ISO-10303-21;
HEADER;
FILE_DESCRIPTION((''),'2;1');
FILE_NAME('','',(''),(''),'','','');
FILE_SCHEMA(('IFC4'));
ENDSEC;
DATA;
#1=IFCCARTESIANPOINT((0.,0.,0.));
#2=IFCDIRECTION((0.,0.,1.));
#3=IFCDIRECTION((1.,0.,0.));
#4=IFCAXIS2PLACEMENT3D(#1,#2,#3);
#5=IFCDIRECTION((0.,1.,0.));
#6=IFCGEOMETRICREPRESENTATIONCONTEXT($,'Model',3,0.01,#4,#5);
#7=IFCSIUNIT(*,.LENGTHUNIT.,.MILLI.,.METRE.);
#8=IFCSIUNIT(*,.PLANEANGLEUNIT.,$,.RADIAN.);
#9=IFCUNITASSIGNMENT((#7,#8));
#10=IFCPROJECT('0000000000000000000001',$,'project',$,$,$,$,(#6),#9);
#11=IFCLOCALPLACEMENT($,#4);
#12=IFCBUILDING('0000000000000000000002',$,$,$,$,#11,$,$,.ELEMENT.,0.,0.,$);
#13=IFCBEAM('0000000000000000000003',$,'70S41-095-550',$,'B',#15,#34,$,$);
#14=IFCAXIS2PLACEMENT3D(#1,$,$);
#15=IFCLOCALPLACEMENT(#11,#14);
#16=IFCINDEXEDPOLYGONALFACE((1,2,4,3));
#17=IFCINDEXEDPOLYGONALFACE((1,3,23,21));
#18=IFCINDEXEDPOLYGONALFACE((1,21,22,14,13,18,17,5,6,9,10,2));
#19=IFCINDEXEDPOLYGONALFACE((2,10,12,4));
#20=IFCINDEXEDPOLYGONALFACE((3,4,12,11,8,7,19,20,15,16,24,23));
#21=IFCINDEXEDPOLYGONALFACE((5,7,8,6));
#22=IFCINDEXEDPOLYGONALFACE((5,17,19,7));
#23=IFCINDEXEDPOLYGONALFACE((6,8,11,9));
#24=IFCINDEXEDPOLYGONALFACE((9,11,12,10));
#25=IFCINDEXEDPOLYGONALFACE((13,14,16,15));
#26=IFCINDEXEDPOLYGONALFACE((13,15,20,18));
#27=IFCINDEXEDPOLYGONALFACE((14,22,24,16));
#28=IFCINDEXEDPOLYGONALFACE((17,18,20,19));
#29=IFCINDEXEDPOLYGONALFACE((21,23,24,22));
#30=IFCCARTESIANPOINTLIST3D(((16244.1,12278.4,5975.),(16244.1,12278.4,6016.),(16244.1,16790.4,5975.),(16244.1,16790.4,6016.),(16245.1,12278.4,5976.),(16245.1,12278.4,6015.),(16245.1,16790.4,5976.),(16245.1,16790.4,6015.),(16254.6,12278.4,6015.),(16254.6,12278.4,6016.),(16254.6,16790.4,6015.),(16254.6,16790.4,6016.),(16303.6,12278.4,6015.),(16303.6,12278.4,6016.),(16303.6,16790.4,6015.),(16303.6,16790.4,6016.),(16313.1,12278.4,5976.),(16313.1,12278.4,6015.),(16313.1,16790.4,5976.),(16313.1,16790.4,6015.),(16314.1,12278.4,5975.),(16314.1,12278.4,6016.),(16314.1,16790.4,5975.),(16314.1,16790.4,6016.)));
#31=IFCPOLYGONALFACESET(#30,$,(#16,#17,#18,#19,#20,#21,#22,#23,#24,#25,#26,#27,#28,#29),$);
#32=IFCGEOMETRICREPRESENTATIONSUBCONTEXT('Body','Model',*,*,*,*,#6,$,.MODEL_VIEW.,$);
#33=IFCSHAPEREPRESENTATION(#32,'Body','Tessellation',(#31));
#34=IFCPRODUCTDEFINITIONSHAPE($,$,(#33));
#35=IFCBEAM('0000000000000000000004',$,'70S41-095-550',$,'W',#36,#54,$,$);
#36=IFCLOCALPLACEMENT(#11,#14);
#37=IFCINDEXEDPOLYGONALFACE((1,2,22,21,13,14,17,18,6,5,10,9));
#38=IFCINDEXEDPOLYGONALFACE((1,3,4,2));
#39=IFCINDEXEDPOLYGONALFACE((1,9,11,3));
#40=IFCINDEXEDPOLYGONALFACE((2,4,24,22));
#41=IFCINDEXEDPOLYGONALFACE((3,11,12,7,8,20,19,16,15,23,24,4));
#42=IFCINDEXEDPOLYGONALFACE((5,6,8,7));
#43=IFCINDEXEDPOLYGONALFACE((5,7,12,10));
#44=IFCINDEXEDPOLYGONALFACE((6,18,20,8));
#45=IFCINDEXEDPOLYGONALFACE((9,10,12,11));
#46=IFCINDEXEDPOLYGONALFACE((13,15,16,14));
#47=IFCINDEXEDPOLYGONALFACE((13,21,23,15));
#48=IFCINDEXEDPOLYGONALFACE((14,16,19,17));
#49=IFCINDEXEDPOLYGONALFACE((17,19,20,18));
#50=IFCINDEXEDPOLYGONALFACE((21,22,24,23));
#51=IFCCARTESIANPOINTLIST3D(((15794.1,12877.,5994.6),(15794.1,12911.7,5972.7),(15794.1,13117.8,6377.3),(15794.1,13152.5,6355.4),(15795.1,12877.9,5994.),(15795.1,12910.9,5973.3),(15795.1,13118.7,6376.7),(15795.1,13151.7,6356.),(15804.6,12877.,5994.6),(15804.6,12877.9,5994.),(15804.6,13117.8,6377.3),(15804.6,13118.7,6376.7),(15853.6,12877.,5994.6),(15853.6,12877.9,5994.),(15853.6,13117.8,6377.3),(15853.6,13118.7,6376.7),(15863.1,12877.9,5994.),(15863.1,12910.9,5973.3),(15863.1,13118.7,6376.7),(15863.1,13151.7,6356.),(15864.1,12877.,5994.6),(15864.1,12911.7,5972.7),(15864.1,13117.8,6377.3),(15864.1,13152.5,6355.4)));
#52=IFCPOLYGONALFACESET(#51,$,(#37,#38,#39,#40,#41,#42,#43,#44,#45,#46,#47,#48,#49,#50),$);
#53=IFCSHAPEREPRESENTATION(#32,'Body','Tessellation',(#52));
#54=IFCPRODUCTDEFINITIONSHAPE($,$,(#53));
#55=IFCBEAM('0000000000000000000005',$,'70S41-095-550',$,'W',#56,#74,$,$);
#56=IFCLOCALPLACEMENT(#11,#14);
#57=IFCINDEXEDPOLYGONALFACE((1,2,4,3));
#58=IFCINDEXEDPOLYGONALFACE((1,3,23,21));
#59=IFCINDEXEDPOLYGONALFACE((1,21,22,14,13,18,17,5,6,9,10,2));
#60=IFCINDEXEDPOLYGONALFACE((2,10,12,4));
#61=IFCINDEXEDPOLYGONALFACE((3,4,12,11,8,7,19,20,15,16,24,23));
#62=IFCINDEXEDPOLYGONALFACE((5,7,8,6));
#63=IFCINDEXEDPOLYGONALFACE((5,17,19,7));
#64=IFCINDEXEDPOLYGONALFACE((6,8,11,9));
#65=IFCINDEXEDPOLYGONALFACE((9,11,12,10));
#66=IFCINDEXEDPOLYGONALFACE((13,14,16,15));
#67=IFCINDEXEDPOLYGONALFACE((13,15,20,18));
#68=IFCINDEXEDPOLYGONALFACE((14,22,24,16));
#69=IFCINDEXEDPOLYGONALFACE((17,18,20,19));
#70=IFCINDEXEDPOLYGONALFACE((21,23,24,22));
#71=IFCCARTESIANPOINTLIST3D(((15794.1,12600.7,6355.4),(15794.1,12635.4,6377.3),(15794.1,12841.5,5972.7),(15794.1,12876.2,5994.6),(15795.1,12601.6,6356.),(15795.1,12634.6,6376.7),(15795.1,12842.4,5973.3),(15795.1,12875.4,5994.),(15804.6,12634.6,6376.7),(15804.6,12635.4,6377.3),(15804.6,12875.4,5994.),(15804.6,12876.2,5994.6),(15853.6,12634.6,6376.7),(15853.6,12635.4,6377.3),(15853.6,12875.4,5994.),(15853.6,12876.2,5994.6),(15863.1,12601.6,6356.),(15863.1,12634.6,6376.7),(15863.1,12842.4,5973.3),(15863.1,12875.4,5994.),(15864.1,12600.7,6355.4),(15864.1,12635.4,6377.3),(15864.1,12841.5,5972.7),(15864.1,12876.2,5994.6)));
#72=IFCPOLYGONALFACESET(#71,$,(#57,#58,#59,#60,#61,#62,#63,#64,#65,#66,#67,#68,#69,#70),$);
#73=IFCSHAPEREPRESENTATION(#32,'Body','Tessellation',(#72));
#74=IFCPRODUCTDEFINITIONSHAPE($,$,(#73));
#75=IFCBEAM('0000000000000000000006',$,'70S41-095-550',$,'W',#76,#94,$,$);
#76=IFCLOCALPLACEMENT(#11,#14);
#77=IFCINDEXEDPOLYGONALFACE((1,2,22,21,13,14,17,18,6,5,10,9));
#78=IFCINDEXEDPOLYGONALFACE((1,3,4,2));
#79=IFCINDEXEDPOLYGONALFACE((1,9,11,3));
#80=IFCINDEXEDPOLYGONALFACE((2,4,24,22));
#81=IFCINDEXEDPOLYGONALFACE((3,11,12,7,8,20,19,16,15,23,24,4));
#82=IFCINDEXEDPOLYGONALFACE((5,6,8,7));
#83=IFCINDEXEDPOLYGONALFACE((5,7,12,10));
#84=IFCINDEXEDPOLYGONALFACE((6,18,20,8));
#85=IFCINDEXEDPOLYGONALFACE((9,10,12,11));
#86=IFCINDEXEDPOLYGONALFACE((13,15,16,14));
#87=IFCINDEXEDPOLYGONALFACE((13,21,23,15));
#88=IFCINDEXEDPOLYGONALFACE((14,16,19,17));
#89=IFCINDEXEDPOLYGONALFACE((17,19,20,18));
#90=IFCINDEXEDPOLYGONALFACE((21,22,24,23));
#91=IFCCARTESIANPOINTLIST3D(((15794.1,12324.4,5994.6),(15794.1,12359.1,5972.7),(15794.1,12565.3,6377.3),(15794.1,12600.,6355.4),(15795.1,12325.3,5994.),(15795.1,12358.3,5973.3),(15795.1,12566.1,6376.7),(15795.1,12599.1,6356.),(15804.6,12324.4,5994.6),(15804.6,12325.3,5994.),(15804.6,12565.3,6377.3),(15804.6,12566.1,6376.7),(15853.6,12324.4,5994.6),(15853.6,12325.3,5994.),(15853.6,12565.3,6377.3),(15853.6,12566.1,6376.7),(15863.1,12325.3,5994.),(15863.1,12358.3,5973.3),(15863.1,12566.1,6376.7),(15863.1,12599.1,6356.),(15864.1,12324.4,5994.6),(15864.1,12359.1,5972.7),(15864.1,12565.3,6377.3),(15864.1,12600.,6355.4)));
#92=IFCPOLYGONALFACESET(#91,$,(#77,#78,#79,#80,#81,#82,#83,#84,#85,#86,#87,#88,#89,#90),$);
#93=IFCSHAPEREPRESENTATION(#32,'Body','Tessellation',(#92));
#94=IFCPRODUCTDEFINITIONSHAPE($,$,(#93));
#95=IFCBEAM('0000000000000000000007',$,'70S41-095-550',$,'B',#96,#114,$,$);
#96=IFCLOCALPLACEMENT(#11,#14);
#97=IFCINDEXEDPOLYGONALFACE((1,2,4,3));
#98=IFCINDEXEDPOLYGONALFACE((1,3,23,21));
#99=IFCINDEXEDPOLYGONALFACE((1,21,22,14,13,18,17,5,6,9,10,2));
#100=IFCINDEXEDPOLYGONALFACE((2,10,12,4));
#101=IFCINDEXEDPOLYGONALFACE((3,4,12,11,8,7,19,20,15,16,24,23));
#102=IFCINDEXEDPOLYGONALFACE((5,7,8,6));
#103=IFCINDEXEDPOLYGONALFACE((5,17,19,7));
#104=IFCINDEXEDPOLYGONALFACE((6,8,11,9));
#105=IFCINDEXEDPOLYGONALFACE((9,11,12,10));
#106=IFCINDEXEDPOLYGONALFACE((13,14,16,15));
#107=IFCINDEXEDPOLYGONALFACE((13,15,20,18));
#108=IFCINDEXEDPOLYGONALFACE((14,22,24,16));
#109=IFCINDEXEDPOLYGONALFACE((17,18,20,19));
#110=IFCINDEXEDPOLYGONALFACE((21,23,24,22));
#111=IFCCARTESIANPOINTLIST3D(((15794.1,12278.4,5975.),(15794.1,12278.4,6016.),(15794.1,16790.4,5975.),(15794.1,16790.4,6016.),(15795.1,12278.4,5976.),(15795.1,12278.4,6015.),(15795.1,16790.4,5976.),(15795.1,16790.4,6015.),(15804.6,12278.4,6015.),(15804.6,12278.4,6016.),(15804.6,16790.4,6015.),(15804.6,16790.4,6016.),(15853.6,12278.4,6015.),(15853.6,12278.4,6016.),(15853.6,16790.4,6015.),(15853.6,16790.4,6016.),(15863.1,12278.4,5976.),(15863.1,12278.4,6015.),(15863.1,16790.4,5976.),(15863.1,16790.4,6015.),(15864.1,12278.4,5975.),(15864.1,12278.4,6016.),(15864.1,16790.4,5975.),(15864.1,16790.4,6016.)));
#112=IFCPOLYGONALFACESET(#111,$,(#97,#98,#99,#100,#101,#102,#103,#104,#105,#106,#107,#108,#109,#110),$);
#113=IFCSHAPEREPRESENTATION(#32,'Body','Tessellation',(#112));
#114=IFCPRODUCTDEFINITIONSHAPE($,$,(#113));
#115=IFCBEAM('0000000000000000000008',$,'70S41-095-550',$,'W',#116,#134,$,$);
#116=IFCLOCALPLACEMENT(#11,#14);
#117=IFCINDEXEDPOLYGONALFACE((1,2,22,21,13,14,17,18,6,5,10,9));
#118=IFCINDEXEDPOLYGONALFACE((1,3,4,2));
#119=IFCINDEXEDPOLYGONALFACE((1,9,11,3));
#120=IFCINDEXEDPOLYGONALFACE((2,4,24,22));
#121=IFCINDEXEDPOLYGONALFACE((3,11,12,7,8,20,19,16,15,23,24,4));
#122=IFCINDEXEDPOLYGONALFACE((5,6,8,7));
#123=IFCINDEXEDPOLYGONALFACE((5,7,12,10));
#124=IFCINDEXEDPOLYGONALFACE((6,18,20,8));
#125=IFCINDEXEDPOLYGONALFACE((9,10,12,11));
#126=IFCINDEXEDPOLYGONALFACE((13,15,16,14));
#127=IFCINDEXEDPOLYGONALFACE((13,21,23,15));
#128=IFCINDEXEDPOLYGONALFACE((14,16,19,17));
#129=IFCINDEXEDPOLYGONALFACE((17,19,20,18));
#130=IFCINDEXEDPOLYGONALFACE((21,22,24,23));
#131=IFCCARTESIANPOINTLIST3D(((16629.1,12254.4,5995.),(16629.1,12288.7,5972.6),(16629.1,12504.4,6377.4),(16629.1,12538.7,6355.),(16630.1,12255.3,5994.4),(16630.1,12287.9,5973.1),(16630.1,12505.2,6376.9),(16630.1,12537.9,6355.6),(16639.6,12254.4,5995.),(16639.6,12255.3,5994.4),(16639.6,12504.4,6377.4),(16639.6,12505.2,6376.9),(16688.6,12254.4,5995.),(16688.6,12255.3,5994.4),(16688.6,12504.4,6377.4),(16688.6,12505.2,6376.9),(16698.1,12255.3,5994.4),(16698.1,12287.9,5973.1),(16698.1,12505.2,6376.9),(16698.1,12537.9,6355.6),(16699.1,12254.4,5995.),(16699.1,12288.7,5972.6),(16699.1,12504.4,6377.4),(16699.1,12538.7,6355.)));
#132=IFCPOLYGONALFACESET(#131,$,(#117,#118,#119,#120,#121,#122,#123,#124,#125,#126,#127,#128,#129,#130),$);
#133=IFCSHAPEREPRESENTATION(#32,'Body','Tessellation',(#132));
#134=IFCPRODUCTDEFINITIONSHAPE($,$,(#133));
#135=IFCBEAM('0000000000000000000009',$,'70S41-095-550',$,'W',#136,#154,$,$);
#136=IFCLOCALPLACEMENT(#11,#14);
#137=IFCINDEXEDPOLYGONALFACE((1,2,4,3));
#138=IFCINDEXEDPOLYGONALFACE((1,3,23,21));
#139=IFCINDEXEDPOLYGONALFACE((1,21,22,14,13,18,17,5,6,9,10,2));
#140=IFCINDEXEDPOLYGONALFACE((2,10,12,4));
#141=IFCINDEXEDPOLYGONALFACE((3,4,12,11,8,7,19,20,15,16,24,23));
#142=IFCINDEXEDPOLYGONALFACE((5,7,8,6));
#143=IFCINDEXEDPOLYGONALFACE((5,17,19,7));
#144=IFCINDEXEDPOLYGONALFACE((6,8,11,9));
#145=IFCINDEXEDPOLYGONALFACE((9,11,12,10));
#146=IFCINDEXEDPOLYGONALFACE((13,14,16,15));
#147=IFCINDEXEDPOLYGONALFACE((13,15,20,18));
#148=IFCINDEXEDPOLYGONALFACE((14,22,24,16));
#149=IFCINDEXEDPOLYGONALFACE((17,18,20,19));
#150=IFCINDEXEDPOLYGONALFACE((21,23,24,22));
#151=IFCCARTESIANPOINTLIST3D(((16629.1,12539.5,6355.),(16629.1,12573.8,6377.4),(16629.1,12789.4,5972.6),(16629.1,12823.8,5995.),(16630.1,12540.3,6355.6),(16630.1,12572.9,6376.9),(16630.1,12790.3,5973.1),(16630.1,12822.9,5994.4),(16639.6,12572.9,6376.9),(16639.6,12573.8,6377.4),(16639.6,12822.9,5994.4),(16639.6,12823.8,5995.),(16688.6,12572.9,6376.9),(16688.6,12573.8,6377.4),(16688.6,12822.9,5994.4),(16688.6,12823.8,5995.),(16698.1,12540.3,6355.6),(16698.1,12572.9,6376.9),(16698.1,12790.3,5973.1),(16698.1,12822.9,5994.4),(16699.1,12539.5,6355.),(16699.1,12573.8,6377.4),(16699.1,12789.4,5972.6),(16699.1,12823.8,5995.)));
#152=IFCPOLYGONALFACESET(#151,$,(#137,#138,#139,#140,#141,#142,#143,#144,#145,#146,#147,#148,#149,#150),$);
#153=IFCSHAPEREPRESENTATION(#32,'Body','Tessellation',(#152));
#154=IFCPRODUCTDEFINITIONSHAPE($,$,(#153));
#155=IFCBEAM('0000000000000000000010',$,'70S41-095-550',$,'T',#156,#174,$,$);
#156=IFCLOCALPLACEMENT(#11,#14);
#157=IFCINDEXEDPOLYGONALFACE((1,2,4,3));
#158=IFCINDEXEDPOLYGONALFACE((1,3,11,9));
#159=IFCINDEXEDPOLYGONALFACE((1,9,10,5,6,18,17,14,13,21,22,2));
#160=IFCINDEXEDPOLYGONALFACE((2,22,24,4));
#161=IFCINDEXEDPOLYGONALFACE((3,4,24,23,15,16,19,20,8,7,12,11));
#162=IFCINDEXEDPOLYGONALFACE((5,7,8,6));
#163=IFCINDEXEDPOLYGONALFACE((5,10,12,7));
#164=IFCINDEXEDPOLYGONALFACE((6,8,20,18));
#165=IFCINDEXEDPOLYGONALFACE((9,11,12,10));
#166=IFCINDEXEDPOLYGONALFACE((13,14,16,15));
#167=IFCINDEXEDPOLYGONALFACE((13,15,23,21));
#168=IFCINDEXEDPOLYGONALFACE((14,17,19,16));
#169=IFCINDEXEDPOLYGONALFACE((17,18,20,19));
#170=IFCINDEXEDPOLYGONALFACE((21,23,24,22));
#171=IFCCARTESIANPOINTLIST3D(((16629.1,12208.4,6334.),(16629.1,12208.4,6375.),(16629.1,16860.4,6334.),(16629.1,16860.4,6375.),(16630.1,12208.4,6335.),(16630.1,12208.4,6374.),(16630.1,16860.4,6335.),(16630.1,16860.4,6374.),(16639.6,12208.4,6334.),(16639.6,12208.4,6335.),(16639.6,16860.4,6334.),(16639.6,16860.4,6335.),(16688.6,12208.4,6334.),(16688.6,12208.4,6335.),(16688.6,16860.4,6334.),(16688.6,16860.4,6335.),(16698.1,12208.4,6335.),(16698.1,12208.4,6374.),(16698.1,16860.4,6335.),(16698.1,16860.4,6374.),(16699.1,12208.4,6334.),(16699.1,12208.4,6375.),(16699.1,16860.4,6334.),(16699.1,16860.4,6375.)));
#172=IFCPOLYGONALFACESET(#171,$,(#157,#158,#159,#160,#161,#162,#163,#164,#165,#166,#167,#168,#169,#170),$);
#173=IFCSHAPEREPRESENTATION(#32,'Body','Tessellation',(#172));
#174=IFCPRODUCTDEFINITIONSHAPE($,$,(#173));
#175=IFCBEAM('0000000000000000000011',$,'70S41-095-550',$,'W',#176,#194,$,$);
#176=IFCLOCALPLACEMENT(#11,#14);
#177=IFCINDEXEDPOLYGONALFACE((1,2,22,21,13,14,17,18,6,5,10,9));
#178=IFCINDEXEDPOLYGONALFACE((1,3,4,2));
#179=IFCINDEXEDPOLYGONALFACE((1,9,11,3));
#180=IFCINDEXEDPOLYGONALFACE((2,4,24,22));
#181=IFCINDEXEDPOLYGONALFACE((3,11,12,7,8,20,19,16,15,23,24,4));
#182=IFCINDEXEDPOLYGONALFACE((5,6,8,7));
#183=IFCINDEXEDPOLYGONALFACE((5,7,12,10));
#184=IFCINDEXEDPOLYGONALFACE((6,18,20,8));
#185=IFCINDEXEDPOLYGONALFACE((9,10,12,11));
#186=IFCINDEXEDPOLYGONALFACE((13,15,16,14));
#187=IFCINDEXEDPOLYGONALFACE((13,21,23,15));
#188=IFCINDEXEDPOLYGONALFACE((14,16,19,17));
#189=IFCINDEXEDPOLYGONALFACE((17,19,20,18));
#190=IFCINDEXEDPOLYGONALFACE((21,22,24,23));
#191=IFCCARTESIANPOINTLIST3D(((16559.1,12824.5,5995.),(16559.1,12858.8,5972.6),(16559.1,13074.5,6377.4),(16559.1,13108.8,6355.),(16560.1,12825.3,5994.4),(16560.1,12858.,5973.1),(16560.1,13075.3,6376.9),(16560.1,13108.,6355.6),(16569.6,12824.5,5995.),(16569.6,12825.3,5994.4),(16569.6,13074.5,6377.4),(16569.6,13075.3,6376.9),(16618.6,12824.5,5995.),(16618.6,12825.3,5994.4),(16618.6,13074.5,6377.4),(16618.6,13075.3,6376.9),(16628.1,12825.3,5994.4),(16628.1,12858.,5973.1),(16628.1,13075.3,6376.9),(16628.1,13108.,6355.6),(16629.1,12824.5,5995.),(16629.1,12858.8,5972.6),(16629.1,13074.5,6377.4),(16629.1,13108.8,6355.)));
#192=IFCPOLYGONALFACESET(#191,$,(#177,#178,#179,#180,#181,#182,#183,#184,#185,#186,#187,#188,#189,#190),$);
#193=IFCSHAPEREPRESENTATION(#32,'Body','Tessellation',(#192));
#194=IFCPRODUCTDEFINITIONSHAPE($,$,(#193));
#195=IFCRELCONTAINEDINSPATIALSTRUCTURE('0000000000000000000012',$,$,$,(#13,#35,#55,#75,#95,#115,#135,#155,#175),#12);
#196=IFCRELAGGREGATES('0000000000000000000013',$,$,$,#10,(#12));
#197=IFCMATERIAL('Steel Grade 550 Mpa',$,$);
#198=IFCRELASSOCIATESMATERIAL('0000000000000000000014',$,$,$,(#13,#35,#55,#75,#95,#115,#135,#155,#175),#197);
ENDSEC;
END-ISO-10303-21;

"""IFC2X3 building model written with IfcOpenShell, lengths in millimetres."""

from ifc_helpers import new_model, si_unit, direction, frame, origin, origin_with_axes, origin_2d_with_axis, place, context, subcontext, project, spatial, c_section, extrude, source, transform, mapped, material, element, save


model = new_model("IFC2X3")

# Units and contexts
model_context = context("Model", 3, precision=0.01, world=origin_with_axes(), true_north=direction((0.0, 1.0, 0.0)))
body_context = subcontext(model_context, "Body", "Model", "MODEL_VIEW")
ifc_project = project(units=[si_unit("LENGTHUNIT", "METRE", prefix="MILLI"), si_unit("PLANEANGLEUNIT", "RADIAN")], contexts=[model_context])

# Building
building_placement = place(None, origin_with_axes())
building = spatial("IfcBuilding", under=ifc_project, at=building_placement, CompositionType="ELEMENT", ElevationOfRefHeight=0.0, ElevationOfTerrain=0.0)

# Shared definitions
ifc_material = material(Name="Steel Grade 550 Mpa")

# Beams
shared_shape_1 = source(origin(), body_context, "Body", "SweptSolid", [
    extrude(c_section(Depth=70.0, Width=41.0, WallThickness=1.0, Girth=10.5, at=origin_2d_with_axis()), origin_with_axes(), (0.0, 0.0, 1.0), 4512.0),
])
beam_1_placement = place(None, frame((16279.1, 12278.4, 5995.5), z_axis=(0.0, 1.0, 0.0), x_axis=(0.0, 0.0, 1.0)))
element("IfcBeam", 1, at=beam_1_placement, inside=building, material=ifc_material, Name="70S41-095-550", ObjectType="B", context=body_context, shape_type="MappedRepresentation", body=[
    mapped(shared_shape_1, transform((0.0, 0.0, 0.0), scale=1.0)),
])
shared_shape_2 = source(origin(), body_context, "Body", "SweptSolid", [
    extrude(c_section(Depth=70.0, Width=41.0, WallThickness=1.0, Girth=10.5, at=origin_2d_with_axis()), origin_with_axes(), (0.0, 0.0, 1.0), 452.2),
])
beam_2_placement = place(None, frame((15829.1, 12894.4, 5983.7), z_axis=(0.0, 0.532581, 0.846379), x_axis=(0.0, -0.846379, 0.532581)))
element("IfcBeam", 2, at=beam_2_placement, inside=building, material=ifc_material, Name="70S41-095-550", ObjectType="W", context=body_context, shape_type="MappedRepresentation", body=[
    mapped(shared_shape_2, transform((0.0, 0.0, 0.0), scale=1.0)),
])
shared_shape_3 = source(origin(), body_context, "Body", "SweptSolid", [
    extrude(c_section(Depth=70.0, Width=41.0, WallThickness=1.0, Girth=10.5, at=origin_2d_with_axis()), origin_with_axes(), (0.0, 0.0, 1.0), 452.2),
])
beam_3_placement = place(None, frame((15829.1, 12618.1, 6366.3), z_axis=(0.0, 0.532581, -0.846379), x_axis=(0.0, 0.846379, 0.532581)))
element("IfcBeam", 3, at=beam_3_placement, inside=building, material=ifc_material, Name="70S41-095-550", ObjectType="W", context=body_context, shape_type="MappedRepresentation", body=[
    mapped(shared_shape_3, transform((0.0, 0.0, 0.0), scale=1.0)),
])
shared_shape_4 = source(origin(), body_context, "Body", "SweptSolid", [
    extrude(c_section(Depth=70.0, Width=41.0, WallThickness=1.0, Girth=10.5, at=origin_2d_with_axis()), origin_with_axes(), (0.0, 0.0, 1.0), 452.2),
])
beam_4_placement = place(None, frame((15829.1, 12341.8, 5983.7), z_axis=(0.0, 0.532581, 0.846379), x_axis=(0.0, -0.846379, 0.532581)))
element("IfcBeam", 4, at=beam_4_placement, inside=building, material=ifc_material, Name="70S41-095-550", ObjectType="W", context=body_context, shape_type="MappedRepresentation", body=[
    mapped(shared_shape_4, transform((0.0, 0.0, 0.0), scale=1.0)),
])
shared_shape_5 = source(origin(), body_context, "Body", "SweptSolid", [
    extrude(c_section(Depth=70.0, Width=41.0, WallThickness=1.0, Girth=10.5, at=origin_2d_with_axis()), origin_with_axes(), (0.0, 0.0, 1.0), 4512.0),
])
beam_5_placement = place(None, frame((15829.1, 12278.4, 5995.5), z_axis=(0.0, 1.0, 0.0), x_axis=(0.0, 0.0, 1.0)))
element("IfcBeam", 5, at=beam_5_placement, inside=building, material=ifc_material, Name="70S41-095-550", ObjectType="B", context=body_context, shape_type="MappedRepresentation", body=[
    mapped(shared_shape_5, transform((0.0, 0.0, 0.0), scale=1.0)),
])
shared_shape_6 = source(origin(), body_context, "Body", "SweptSolid", [
    extrude(c_section(Depth=70.0, Width=41.0, WallThickness=1.0, Girth=10.5, at=origin_2d_with_axis()), origin_with_axes(), (0.0, 0.0, 1.0), 456.9),
])
beam_6_placement = place(None, frame((16664.1, 12521.6, 6366.2), z_axis=(0.0, -0.547116, -0.837057), x_axis=(0.0, -0.837057, 0.547116)))
element("IfcBeam", 6, at=beam_6_placement, inside=building, material=ifc_material, Name="70S41-095-550", ObjectType="W", context=body_context, shape_type="MappedRepresentation", body=[
    mapped(shared_shape_6, transform((0.0, 0.0, 0.0), scale=1.0)),
])
shared_shape_7 = source(origin(), body_context, "Body", "SweptSolid", [
    extrude(c_section(Depth=70.0, Width=41.0, WallThickness=1.0, Girth=10.5, at=origin_2d_with_axis()), origin_with_axes(), (0.0, 0.0, 1.0), 456.9),
])
beam_7_placement = place(None, frame((16664.1, 12806.6, 5983.8), z_axis=(0.0, -0.547116, 0.837057), x_axis=(0.0, 0.837057, 0.547116)))
element("IfcBeam", 7, at=beam_7_placement, inside=building, material=ifc_material, Name="70S41-095-550", ObjectType="W", context=body_context, shape_type="MappedRepresentation", body=[
    mapped(shared_shape_7, transform((0.0, 0.0, 0.0), scale=1.0)),
])
shared_shape_8 = source(origin(), body_context, "Body", "SweptSolid", [
    extrude(c_section(Depth=70.0, Width=41.0, WallThickness=1.0, Girth=10.5, at=origin_2d_with_axis()), origin_with_axes(), (0.0, 0.0, 1.0), 4652.0),
])
beam_8_placement = place(None, frame((16664.1, 12208.4, 6354.5), z_axis=(0.0, 1.0, 0.0), x_axis=(0.0, 0.0, -1.0)))
element("IfcBeam", 8, at=beam_8_placement, inside=building, material=ifc_material, Name="70S41-095-550", ObjectType="T", context=body_context, shape_type="MappedRepresentation", body=[
    mapped(shared_shape_8, transform((0.0, 0.0, 0.0), scale=1.0)),
])
shared_shape_9 = source(origin(), body_context, "Body", "SweptSolid", [
    extrude(c_section(Depth=70.0, Width=41.0, WallThickness=1.0, Girth=10.5, at=origin_2d_with_axis()), origin_with_axes(), (0.0, 0.0, 1.0), 456.9),
])
beam_9_placement = place(None, frame((16594.1, 12841.7, 5983.8), z_axis=(0.0, 0.547116, 0.837057), x_axis=(0.0, -0.837057, 0.547116)))
element("IfcBeam", 9, at=beam_9_placement, inside=building, material=ifc_material, Name="70S41-095-550", ObjectType="W", context=body_context, shape_type="MappedRepresentation", body=[
    mapped(shared_shape_9, transform((0.0, 0.0, 0.0), scale=1.0)),
])

save(model, "model.ifc")
